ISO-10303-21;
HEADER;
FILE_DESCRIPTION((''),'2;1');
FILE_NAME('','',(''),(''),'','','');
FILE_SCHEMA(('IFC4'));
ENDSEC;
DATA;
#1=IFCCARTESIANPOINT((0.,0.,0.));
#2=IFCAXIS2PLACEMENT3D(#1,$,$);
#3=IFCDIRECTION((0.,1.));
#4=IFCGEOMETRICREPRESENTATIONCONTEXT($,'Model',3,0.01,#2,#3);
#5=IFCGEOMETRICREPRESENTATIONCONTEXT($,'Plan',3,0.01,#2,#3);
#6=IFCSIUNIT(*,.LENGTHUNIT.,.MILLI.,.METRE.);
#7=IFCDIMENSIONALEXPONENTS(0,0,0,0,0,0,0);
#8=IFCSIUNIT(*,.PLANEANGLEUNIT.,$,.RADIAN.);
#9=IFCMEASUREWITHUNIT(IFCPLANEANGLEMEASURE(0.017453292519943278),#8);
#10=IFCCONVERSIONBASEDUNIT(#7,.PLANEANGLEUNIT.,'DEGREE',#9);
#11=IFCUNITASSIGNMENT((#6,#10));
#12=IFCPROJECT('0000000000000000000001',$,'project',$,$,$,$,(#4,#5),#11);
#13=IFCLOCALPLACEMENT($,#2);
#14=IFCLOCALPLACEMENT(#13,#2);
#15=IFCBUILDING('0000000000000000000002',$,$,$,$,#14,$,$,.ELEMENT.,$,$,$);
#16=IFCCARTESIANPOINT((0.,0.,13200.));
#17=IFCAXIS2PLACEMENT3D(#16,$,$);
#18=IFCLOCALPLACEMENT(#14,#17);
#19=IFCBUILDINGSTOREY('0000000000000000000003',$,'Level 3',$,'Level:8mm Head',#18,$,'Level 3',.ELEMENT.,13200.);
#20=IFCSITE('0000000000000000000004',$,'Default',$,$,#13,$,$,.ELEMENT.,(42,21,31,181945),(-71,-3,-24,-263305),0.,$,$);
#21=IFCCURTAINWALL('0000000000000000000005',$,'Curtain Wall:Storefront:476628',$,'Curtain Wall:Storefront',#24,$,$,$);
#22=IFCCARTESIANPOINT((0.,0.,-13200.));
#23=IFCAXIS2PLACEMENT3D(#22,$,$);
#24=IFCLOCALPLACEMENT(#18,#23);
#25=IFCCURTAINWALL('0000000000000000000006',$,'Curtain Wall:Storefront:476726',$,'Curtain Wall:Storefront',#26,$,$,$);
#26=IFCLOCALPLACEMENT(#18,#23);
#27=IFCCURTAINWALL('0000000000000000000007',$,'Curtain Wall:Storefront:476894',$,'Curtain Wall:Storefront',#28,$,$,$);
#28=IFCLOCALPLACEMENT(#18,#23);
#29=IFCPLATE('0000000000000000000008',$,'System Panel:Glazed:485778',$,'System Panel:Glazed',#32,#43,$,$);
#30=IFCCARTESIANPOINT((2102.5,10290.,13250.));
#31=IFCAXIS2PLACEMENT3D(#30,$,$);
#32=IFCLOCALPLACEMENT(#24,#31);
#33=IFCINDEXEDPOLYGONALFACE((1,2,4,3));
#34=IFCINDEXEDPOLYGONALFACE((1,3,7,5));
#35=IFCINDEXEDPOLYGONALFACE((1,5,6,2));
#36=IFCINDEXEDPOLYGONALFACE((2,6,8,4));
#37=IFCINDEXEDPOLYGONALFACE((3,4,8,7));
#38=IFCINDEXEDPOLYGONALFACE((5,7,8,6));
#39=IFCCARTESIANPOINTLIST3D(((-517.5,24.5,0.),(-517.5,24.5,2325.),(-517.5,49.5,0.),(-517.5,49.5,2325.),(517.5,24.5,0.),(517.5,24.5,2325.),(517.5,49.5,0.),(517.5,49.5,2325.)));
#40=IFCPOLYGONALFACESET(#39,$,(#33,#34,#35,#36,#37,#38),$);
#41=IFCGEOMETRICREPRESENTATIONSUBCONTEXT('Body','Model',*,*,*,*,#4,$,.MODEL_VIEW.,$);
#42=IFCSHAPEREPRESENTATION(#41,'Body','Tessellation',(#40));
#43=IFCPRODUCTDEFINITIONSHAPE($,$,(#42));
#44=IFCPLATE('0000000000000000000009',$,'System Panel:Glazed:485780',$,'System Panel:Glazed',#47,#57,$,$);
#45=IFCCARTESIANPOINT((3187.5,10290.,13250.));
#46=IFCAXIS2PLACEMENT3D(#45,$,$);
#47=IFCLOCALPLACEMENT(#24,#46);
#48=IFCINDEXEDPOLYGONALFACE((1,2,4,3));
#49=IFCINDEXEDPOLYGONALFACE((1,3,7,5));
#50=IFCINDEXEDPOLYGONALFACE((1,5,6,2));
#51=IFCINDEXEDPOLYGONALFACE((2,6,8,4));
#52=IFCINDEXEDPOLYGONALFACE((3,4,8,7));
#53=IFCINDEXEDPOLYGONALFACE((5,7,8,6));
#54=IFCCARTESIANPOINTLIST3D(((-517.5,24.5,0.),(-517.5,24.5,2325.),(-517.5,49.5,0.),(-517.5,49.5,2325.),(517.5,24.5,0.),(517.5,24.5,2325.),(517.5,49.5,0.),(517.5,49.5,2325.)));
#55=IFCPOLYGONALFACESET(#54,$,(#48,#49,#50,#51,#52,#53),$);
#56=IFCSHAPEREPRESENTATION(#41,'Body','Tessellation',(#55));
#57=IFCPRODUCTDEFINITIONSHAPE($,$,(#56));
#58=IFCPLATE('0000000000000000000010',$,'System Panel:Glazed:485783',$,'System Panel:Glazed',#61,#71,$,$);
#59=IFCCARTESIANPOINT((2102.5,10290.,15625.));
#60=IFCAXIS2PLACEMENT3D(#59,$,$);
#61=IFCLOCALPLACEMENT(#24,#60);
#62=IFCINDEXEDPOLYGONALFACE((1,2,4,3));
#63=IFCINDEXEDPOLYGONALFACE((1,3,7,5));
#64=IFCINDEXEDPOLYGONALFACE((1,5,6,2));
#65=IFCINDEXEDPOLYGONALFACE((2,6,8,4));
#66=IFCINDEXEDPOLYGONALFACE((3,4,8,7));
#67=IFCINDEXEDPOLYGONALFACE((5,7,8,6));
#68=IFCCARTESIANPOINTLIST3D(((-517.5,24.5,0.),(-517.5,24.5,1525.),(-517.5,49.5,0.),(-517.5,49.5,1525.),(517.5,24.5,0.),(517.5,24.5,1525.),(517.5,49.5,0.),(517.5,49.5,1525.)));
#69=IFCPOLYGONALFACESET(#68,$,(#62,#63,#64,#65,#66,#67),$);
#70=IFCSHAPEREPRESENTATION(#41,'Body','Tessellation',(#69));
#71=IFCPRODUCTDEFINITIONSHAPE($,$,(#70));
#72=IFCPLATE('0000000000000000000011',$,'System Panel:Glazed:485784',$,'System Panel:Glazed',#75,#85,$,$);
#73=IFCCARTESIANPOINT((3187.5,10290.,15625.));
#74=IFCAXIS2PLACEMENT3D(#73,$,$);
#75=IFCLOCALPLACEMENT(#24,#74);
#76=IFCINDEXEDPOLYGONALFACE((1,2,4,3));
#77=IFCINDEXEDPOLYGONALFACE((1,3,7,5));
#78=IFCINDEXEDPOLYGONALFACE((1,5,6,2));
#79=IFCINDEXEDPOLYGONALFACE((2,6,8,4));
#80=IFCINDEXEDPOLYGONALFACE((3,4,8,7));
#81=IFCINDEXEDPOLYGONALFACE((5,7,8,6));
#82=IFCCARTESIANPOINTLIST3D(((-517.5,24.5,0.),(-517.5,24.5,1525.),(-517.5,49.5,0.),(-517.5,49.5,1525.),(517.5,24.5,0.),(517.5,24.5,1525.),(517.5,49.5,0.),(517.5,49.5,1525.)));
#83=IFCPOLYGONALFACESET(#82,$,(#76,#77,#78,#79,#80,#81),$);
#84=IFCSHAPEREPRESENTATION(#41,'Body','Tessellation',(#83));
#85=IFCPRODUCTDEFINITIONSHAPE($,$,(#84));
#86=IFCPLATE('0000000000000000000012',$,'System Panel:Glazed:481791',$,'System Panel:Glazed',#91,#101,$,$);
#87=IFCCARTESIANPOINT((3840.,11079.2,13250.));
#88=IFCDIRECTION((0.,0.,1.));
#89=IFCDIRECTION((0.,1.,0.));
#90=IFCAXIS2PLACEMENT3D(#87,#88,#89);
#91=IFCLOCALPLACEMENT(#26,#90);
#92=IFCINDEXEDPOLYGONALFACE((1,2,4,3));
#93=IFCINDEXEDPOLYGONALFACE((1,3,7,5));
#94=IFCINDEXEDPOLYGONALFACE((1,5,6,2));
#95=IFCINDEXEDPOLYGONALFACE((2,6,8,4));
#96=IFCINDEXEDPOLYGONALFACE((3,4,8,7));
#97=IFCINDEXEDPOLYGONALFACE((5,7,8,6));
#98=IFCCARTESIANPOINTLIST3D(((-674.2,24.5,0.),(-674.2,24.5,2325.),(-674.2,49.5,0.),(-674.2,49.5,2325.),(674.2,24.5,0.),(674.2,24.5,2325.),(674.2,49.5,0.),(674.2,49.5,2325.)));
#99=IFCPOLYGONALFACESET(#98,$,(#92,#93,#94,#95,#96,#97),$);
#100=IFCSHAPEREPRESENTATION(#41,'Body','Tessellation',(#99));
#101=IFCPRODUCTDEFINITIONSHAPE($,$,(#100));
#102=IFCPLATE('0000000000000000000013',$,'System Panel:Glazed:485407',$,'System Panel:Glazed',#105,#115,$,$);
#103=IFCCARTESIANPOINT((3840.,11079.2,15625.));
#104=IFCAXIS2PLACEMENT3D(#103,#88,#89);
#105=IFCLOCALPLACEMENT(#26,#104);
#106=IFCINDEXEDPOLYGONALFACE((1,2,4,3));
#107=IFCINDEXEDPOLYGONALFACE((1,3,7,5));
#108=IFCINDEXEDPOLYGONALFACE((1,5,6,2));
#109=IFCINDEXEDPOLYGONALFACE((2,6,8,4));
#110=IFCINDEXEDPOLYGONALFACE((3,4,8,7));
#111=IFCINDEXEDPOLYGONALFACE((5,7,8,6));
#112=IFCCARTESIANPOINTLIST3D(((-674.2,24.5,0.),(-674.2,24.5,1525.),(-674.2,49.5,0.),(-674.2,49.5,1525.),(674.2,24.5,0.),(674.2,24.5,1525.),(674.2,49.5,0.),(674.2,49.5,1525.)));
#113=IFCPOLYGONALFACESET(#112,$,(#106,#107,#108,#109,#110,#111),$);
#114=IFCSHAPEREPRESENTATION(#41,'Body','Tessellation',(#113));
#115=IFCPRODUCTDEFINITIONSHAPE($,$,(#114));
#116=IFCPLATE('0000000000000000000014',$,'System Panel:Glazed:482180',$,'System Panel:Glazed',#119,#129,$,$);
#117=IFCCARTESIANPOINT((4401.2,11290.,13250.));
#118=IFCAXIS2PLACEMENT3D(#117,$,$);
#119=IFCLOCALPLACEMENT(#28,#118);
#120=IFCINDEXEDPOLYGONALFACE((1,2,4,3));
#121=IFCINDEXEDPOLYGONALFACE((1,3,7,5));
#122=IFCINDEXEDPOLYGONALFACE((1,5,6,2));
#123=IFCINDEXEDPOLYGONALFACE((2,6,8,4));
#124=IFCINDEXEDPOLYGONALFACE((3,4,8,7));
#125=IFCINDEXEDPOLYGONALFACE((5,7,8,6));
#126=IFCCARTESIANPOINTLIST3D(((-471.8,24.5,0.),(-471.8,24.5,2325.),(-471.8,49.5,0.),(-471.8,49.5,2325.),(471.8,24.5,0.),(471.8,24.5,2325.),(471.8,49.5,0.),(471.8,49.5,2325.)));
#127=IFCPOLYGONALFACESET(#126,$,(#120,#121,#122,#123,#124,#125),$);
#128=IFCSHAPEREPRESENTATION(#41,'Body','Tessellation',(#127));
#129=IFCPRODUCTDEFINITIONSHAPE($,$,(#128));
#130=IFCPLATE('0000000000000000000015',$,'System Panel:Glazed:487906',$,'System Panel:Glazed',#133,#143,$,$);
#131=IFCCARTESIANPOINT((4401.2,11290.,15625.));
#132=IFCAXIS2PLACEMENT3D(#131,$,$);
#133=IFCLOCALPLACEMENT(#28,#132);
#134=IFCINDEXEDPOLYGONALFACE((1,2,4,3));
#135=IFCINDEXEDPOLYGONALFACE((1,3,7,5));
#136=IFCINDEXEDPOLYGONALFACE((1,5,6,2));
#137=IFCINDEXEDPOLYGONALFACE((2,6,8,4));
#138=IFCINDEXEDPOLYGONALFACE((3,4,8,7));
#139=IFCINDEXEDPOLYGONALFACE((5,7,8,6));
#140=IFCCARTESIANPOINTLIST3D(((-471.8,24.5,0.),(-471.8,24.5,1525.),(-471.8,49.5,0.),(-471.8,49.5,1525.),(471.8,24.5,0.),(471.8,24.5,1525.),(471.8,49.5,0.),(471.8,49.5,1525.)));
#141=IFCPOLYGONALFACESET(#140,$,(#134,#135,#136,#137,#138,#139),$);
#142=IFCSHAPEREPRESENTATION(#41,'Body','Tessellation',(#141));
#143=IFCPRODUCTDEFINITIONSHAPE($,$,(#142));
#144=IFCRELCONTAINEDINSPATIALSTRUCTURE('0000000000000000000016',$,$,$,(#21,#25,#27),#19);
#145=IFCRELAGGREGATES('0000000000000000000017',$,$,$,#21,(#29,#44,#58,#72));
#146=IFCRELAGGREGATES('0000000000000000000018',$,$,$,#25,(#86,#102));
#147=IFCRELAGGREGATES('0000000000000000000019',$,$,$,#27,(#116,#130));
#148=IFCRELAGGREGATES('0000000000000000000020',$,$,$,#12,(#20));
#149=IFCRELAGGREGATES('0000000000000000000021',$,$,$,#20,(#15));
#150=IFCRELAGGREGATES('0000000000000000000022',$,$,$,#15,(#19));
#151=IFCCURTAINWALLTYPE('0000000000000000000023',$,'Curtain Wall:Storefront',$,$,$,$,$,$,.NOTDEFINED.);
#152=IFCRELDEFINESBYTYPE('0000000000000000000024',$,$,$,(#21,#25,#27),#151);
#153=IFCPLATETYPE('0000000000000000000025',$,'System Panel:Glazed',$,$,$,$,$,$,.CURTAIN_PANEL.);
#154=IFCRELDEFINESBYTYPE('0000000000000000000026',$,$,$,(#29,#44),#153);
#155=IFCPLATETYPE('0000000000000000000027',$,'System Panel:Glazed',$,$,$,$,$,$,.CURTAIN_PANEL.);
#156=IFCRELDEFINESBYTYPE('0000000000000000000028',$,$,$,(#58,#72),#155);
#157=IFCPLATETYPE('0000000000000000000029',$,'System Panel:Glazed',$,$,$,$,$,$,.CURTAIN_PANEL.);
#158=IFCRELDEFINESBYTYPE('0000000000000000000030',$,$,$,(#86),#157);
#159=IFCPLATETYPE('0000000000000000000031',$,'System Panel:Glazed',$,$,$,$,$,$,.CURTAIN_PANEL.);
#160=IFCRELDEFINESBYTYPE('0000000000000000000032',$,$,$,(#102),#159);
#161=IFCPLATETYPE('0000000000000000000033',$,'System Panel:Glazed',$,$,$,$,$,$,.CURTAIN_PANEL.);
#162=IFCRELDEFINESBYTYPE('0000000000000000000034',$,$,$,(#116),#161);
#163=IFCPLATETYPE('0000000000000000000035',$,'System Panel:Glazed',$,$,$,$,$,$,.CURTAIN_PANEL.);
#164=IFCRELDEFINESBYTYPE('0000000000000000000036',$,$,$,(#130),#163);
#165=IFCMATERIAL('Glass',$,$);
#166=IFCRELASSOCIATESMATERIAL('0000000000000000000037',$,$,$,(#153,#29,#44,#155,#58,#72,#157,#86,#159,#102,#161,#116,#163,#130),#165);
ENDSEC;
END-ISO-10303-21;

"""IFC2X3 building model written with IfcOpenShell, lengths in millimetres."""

from ifc_helpers import new_model, entity, si_unit, converted_unit, direction, frame, origin, origin_2d_with_axis, place, context, subcontext, project, spatial, rectangle, extrude, source, transform, mapped, material, type_object, type_shapes, element, aggregate, save


model = new_model("IFC2X3")

# Units and contexts
model_context = context("Model", 3, precision=0.01, world=origin(), true_north=direction((0.0, 1.0)))
plan_context = context("Plan", 3, precision=0.01, world=origin(), true_north=direction((0.0, 1.0)))
body_context = subcontext(model_context, "Body", "Model", "MODEL_VIEW")
ifc_project = project(units=[si_unit("LENGTHUNIT", "METRE", prefix="MILLI"), converted_unit("PLANEANGLEUNIT", "DEGREE", entity("IfcPlaneAngleMeasure", 0.017453292519943278), si_unit("PLANEANGLEUNIT", "RADIAN"), dimensions=[0, 0, 0, 0, 0, 0, 0])], contexts=[model_context, plan_context])

# Site, building, storey
site_placement = place(None, origin())
site = spatial("IfcSite", under=ifc_project, at=site_placement, Name="Default", CompositionType="ELEMENT", RefLatitude=(42, 21, 31, 181945), RefLongitude=(-71, -3, -24, -263305), RefElevation=0.0)
building_placement = place(site_placement, origin())
building = spatial("IfcBuilding", under=site, at=building_placement, CompositionType="ELEMENT")
storey_placement = place(building_placement, frame((0.0, 0.0, 13200.0)))
storey = spatial("IfcBuildingStorey", under=building, at=storey_placement, Name="Level 3", ObjectType="Level:8mm Head", LongName="Level 3", CompositionType="ELEMENT", Elevation=13200.0)

# Curtain walls
curtain_wall_type = type_object("IfcCurtainWallType", Name="Curtain Wall:Storefront", PredefinedType="NOTDEFINED")
curtain_wall_1_placement = place(storey_placement, frame((0.0, 0.0, -13200.0)))
curtain_wall_1 = element("IfcCurtainWall", 1, at=curtain_wall_1_placement, inside=storey, type_object=curtain_wall_type, Name="Curtain Wall:Storefront:476628", ObjectType="Curtain Wall:Storefront")
curtain_wall_2_placement = place(storey_placement, frame((0.0, 0.0, -13200.0)))
curtain_wall_2 = element("IfcCurtainWall", 2, at=curtain_wall_2_placement, inside=storey, type_object=curtain_wall_type, Name="Curtain Wall:Storefront:476726", ObjectType="Curtain Wall:Storefront")
curtain_wall_3_placement = place(storey_placement, frame((0.0, 0.0, -13200.0)))
curtain_wall_3 = element("IfcCurtainWall", 3, at=curtain_wall_3_placement, inside=storey, type_object=curtain_wall_type, Name="Curtain Wall:Storefront:476894", ObjectType="Curtain Wall:Storefront")

# Plates
ifc_material_1 = material(Name="Glass")
plate_type_1 = type_object("IfcPlateType", Name="System Panel:Glazed", PredefinedType="CURTAIN_PANEL", material=ifc_material_1)
shared_shape_1 = source(origin(), body_context, "Body", "SweptSolid", [
    extrude(rectangle(XDim=25.0, YDim=1035.0, at=origin_2d_with_axis()), frame((0.0, 37.0, 0.0), z_axis=(0.0, 0.0, 1.0), x_axis=(0.0, 1.0, 0.0)), (0.0, 0.0, 1.0), 2325.0),
])
type_shapes(plate_type_1, [shared_shape_1])
plate_1_placement = place(curtain_wall_1_placement, frame((2102.5, 10290.0, 13250.0)))
plate_1 = element("IfcPlate", 4, at=plate_1_placement, type_object=plate_type_1, material=ifc_material_1, Name="System Panel:Glazed:485778", ObjectType="System Panel:Glazed", context=body_context, shape_type="MappedRepresentation", body=[
    mapped(shared_shape_1, transform((0.0, 0.0, 0.0), scale=1.0)),
])
plate_2_placement = place(curtain_wall_1_placement, frame((3187.5, 10290.0, 13250.0)))
plate_2 = element("IfcPlate", 5, at=plate_2_placement, type_object=plate_type_1, material=ifc_material_1, Name="System Panel:Glazed:485780", ObjectType="System Panel:Glazed", context=body_context, shape_type="MappedRepresentation", body=[
    mapped(shared_shape_1, transform((0.0, 0.0, 0.0), scale=1.0)),
])
plate_type_2 = type_object("IfcPlateType", Name="System Panel:Glazed", PredefinedType="CURTAIN_PANEL", material=ifc_material_1)
shared_shape_2 = source(origin(), body_context, "Body", "SweptSolid", [
    extrude(rectangle(XDim=25.0, YDim=1035.0, at=origin_2d_with_axis()), frame((0.0, 37.0, 0.0), z_axis=(0.0, 0.0, 1.0), x_axis=(0.0, 1.0, 0.0)), (0.0, 0.0, 1.0), 1525.0),
])
type_shapes(plate_type_2, [shared_shape_2])
plate_3_placement = place(curtain_wall_1_placement, frame((2102.5, 10290.0, 15625.0)))
plate_3 = element("IfcPlate", 6, at=plate_3_placement, type_object=plate_type_2, material=ifc_material_1, Name="System Panel:Glazed:485783", ObjectType="System Panel:Glazed", context=body_context, shape_type="MappedRepresentation", body=[
    mapped(shared_shape_2, transform((0.0, 0.0, 0.0), scale=1.0)),
])
plate_4_placement = place(curtain_wall_1_placement, frame((3187.5, 10290.0, 15625.0)))
plate_4 = element("IfcPlate", 7, at=plate_4_placement, type_object=plate_type_2, material=ifc_material_1, Name="System Panel:Glazed:485784", ObjectType="System Panel:Glazed", context=body_context, shape_type="MappedRepresentation", body=[
    mapped(shared_shape_2, transform((0.0, 0.0, 0.0), scale=1.0)),
])
aggregate(curtain_wall_1, [plate_1, plate_2, plate_3, plate_4])
plate_type_3 = type_object("IfcPlateType", Name="System Panel:Glazed", PredefinedType="CURTAIN_PANEL", material=ifc_material_1)
shared_shape_3 = source(origin(), body_context, "Body", "SweptSolid", [
    extrude(rectangle(XDim=25.0, YDim=1348.3, at=origin_2d_with_axis()), frame((0.0, 37.0, 0.0), z_axis=(0.0, 0.0, 1.0), x_axis=(0.0, 1.0, 0.0)), (0.0, 0.0, 1.0), 2325.0),
])
type_shapes(plate_type_3, [shared_shape_3])
plate_5_placement = place(curtain_wall_2_placement, frame((3840.0, 11079.2, 13250.0), z_axis=(0.0, 0.0, 1.0), x_axis=(0.0, 1.0, 0.0)))
plate_5 = element("IfcPlate", 8, at=plate_5_placement, type_object=plate_type_3, material=ifc_material_1, Name="System Panel:Glazed:481791", ObjectType="System Panel:Glazed", context=body_context, shape_type="MappedRepresentation", body=[
    mapped(shared_shape_3, transform((0.0, 0.0, 0.0), scale=1.0)),
])
plate_type_4 = type_object("IfcPlateType", Name="System Panel:Glazed", PredefinedType="CURTAIN_PANEL", material=ifc_material_1)
shared_shape_4 = source(origin(), body_context, "Body", "SweptSolid", [
    extrude(rectangle(XDim=25.0, YDim=1348.3, at=origin_2d_with_axis()), frame((0.0, 37.0, 0.0), z_axis=(0.0, 0.0, 1.0), x_axis=(0.0, 1.0, 0.0)), (0.0, 0.0, 1.0), 1525.0),
])
type_shapes(plate_type_4, [shared_shape_4])
plate_6_placement = place(curtain_wall_2_placement, frame((3840.0, 11079.2, 15625.0), z_axis=(0.0, 0.0, 1.0), x_axis=(0.0, 1.0, 0.0)))
plate_6 = element("IfcPlate", 9, at=plate_6_placement, type_object=plate_type_4, material=ifc_material_1, Name="System Panel:Glazed:485407", ObjectType="System Panel:Glazed", context=body_context, shape_type="MappedRepresentation", body=[
    mapped(shared_shape_4, transform((0.0, 0.0, 0.0), scale=1.0)),
])
aggregate(curtain_wall_2, [plate_5, plate_6])
plate_type_5 = type_object("IfcPlateType", Name="System Panel:Glazed", PredefinedType="CURTAIN_PANEL", material=ifc_material_1)
shared_shape_5 = source(origin(), body_context, "Body", "SweptSolid", [
    extrude(rectangle(XDim=25.0, YDim=943.5, at=origin_2d_with_axis()), frame((0.0, 37.0, 0.0), z_axis=(0.0, 0.0, 1.0), x_axis=(0.0, 1.0, 0.0)), (0.0, 0.0, 1.0), 2325.0),
])
type_shapes(plate_type_5, [shared_shape_5])
plate_7_placement = place(curtain_wall_3_placement, frame((4401.2, 11290.0, 13250.0)))
plate_7 = element("IfcPlate", 10, at=plate_7_placement, type_object=plate_type_5, material=ifc_material_1, Name="System Panel:Glazed:482180", ObjectType="System Panel:Glazed", context=body_context, shape_type="MappedRepresentation", body=[
    mapped(shared_shape_5, transform((0.0, 0.0, 0.0), scale=1.0)),
])
plate_type_6 = type_object("IfcPlateType", Name="System Panel:Glazed", PredefinedType="CURTAIN_PANEL", material=ifc_material_1)
shared_shape_6 = source(origin(), body_context, "Body", "SweptSolid", [
    extrude(rectangle(XDim=25.0, YDim=943.5, at=origin_2d_with_axis()), frame((0.0, 37.0, 0.0), z_axis=(0.0, 0.0, 1.0), x_axis=(0.0, 1.0, 0.0)), (0.0, 0.0, 1.0), 1525.0),
])
type_shapes(plate_type_6, [shared_shape_6])
plate_8_placement = place(curtain_wall_3_placement, frame((4401.2, 11290.0, 15625.0)))
plate_8 = element("IfcPlate", 11, at=plate_8_placement, type_object=plate_type_6, material=ifc_material_1, Name="System Panel:Glazed:487906", ObjectType="System Panel:Glazed", context=body_context, shape_type="MappedRepresentation", body=[
    mapped(shared_shape_6, transform((0.0, 0.0, 0.0), scale=1.0)),
])
aggregate(curtain_wall_3, [plate_7, plate_8])

save(model, "model.ifc")
